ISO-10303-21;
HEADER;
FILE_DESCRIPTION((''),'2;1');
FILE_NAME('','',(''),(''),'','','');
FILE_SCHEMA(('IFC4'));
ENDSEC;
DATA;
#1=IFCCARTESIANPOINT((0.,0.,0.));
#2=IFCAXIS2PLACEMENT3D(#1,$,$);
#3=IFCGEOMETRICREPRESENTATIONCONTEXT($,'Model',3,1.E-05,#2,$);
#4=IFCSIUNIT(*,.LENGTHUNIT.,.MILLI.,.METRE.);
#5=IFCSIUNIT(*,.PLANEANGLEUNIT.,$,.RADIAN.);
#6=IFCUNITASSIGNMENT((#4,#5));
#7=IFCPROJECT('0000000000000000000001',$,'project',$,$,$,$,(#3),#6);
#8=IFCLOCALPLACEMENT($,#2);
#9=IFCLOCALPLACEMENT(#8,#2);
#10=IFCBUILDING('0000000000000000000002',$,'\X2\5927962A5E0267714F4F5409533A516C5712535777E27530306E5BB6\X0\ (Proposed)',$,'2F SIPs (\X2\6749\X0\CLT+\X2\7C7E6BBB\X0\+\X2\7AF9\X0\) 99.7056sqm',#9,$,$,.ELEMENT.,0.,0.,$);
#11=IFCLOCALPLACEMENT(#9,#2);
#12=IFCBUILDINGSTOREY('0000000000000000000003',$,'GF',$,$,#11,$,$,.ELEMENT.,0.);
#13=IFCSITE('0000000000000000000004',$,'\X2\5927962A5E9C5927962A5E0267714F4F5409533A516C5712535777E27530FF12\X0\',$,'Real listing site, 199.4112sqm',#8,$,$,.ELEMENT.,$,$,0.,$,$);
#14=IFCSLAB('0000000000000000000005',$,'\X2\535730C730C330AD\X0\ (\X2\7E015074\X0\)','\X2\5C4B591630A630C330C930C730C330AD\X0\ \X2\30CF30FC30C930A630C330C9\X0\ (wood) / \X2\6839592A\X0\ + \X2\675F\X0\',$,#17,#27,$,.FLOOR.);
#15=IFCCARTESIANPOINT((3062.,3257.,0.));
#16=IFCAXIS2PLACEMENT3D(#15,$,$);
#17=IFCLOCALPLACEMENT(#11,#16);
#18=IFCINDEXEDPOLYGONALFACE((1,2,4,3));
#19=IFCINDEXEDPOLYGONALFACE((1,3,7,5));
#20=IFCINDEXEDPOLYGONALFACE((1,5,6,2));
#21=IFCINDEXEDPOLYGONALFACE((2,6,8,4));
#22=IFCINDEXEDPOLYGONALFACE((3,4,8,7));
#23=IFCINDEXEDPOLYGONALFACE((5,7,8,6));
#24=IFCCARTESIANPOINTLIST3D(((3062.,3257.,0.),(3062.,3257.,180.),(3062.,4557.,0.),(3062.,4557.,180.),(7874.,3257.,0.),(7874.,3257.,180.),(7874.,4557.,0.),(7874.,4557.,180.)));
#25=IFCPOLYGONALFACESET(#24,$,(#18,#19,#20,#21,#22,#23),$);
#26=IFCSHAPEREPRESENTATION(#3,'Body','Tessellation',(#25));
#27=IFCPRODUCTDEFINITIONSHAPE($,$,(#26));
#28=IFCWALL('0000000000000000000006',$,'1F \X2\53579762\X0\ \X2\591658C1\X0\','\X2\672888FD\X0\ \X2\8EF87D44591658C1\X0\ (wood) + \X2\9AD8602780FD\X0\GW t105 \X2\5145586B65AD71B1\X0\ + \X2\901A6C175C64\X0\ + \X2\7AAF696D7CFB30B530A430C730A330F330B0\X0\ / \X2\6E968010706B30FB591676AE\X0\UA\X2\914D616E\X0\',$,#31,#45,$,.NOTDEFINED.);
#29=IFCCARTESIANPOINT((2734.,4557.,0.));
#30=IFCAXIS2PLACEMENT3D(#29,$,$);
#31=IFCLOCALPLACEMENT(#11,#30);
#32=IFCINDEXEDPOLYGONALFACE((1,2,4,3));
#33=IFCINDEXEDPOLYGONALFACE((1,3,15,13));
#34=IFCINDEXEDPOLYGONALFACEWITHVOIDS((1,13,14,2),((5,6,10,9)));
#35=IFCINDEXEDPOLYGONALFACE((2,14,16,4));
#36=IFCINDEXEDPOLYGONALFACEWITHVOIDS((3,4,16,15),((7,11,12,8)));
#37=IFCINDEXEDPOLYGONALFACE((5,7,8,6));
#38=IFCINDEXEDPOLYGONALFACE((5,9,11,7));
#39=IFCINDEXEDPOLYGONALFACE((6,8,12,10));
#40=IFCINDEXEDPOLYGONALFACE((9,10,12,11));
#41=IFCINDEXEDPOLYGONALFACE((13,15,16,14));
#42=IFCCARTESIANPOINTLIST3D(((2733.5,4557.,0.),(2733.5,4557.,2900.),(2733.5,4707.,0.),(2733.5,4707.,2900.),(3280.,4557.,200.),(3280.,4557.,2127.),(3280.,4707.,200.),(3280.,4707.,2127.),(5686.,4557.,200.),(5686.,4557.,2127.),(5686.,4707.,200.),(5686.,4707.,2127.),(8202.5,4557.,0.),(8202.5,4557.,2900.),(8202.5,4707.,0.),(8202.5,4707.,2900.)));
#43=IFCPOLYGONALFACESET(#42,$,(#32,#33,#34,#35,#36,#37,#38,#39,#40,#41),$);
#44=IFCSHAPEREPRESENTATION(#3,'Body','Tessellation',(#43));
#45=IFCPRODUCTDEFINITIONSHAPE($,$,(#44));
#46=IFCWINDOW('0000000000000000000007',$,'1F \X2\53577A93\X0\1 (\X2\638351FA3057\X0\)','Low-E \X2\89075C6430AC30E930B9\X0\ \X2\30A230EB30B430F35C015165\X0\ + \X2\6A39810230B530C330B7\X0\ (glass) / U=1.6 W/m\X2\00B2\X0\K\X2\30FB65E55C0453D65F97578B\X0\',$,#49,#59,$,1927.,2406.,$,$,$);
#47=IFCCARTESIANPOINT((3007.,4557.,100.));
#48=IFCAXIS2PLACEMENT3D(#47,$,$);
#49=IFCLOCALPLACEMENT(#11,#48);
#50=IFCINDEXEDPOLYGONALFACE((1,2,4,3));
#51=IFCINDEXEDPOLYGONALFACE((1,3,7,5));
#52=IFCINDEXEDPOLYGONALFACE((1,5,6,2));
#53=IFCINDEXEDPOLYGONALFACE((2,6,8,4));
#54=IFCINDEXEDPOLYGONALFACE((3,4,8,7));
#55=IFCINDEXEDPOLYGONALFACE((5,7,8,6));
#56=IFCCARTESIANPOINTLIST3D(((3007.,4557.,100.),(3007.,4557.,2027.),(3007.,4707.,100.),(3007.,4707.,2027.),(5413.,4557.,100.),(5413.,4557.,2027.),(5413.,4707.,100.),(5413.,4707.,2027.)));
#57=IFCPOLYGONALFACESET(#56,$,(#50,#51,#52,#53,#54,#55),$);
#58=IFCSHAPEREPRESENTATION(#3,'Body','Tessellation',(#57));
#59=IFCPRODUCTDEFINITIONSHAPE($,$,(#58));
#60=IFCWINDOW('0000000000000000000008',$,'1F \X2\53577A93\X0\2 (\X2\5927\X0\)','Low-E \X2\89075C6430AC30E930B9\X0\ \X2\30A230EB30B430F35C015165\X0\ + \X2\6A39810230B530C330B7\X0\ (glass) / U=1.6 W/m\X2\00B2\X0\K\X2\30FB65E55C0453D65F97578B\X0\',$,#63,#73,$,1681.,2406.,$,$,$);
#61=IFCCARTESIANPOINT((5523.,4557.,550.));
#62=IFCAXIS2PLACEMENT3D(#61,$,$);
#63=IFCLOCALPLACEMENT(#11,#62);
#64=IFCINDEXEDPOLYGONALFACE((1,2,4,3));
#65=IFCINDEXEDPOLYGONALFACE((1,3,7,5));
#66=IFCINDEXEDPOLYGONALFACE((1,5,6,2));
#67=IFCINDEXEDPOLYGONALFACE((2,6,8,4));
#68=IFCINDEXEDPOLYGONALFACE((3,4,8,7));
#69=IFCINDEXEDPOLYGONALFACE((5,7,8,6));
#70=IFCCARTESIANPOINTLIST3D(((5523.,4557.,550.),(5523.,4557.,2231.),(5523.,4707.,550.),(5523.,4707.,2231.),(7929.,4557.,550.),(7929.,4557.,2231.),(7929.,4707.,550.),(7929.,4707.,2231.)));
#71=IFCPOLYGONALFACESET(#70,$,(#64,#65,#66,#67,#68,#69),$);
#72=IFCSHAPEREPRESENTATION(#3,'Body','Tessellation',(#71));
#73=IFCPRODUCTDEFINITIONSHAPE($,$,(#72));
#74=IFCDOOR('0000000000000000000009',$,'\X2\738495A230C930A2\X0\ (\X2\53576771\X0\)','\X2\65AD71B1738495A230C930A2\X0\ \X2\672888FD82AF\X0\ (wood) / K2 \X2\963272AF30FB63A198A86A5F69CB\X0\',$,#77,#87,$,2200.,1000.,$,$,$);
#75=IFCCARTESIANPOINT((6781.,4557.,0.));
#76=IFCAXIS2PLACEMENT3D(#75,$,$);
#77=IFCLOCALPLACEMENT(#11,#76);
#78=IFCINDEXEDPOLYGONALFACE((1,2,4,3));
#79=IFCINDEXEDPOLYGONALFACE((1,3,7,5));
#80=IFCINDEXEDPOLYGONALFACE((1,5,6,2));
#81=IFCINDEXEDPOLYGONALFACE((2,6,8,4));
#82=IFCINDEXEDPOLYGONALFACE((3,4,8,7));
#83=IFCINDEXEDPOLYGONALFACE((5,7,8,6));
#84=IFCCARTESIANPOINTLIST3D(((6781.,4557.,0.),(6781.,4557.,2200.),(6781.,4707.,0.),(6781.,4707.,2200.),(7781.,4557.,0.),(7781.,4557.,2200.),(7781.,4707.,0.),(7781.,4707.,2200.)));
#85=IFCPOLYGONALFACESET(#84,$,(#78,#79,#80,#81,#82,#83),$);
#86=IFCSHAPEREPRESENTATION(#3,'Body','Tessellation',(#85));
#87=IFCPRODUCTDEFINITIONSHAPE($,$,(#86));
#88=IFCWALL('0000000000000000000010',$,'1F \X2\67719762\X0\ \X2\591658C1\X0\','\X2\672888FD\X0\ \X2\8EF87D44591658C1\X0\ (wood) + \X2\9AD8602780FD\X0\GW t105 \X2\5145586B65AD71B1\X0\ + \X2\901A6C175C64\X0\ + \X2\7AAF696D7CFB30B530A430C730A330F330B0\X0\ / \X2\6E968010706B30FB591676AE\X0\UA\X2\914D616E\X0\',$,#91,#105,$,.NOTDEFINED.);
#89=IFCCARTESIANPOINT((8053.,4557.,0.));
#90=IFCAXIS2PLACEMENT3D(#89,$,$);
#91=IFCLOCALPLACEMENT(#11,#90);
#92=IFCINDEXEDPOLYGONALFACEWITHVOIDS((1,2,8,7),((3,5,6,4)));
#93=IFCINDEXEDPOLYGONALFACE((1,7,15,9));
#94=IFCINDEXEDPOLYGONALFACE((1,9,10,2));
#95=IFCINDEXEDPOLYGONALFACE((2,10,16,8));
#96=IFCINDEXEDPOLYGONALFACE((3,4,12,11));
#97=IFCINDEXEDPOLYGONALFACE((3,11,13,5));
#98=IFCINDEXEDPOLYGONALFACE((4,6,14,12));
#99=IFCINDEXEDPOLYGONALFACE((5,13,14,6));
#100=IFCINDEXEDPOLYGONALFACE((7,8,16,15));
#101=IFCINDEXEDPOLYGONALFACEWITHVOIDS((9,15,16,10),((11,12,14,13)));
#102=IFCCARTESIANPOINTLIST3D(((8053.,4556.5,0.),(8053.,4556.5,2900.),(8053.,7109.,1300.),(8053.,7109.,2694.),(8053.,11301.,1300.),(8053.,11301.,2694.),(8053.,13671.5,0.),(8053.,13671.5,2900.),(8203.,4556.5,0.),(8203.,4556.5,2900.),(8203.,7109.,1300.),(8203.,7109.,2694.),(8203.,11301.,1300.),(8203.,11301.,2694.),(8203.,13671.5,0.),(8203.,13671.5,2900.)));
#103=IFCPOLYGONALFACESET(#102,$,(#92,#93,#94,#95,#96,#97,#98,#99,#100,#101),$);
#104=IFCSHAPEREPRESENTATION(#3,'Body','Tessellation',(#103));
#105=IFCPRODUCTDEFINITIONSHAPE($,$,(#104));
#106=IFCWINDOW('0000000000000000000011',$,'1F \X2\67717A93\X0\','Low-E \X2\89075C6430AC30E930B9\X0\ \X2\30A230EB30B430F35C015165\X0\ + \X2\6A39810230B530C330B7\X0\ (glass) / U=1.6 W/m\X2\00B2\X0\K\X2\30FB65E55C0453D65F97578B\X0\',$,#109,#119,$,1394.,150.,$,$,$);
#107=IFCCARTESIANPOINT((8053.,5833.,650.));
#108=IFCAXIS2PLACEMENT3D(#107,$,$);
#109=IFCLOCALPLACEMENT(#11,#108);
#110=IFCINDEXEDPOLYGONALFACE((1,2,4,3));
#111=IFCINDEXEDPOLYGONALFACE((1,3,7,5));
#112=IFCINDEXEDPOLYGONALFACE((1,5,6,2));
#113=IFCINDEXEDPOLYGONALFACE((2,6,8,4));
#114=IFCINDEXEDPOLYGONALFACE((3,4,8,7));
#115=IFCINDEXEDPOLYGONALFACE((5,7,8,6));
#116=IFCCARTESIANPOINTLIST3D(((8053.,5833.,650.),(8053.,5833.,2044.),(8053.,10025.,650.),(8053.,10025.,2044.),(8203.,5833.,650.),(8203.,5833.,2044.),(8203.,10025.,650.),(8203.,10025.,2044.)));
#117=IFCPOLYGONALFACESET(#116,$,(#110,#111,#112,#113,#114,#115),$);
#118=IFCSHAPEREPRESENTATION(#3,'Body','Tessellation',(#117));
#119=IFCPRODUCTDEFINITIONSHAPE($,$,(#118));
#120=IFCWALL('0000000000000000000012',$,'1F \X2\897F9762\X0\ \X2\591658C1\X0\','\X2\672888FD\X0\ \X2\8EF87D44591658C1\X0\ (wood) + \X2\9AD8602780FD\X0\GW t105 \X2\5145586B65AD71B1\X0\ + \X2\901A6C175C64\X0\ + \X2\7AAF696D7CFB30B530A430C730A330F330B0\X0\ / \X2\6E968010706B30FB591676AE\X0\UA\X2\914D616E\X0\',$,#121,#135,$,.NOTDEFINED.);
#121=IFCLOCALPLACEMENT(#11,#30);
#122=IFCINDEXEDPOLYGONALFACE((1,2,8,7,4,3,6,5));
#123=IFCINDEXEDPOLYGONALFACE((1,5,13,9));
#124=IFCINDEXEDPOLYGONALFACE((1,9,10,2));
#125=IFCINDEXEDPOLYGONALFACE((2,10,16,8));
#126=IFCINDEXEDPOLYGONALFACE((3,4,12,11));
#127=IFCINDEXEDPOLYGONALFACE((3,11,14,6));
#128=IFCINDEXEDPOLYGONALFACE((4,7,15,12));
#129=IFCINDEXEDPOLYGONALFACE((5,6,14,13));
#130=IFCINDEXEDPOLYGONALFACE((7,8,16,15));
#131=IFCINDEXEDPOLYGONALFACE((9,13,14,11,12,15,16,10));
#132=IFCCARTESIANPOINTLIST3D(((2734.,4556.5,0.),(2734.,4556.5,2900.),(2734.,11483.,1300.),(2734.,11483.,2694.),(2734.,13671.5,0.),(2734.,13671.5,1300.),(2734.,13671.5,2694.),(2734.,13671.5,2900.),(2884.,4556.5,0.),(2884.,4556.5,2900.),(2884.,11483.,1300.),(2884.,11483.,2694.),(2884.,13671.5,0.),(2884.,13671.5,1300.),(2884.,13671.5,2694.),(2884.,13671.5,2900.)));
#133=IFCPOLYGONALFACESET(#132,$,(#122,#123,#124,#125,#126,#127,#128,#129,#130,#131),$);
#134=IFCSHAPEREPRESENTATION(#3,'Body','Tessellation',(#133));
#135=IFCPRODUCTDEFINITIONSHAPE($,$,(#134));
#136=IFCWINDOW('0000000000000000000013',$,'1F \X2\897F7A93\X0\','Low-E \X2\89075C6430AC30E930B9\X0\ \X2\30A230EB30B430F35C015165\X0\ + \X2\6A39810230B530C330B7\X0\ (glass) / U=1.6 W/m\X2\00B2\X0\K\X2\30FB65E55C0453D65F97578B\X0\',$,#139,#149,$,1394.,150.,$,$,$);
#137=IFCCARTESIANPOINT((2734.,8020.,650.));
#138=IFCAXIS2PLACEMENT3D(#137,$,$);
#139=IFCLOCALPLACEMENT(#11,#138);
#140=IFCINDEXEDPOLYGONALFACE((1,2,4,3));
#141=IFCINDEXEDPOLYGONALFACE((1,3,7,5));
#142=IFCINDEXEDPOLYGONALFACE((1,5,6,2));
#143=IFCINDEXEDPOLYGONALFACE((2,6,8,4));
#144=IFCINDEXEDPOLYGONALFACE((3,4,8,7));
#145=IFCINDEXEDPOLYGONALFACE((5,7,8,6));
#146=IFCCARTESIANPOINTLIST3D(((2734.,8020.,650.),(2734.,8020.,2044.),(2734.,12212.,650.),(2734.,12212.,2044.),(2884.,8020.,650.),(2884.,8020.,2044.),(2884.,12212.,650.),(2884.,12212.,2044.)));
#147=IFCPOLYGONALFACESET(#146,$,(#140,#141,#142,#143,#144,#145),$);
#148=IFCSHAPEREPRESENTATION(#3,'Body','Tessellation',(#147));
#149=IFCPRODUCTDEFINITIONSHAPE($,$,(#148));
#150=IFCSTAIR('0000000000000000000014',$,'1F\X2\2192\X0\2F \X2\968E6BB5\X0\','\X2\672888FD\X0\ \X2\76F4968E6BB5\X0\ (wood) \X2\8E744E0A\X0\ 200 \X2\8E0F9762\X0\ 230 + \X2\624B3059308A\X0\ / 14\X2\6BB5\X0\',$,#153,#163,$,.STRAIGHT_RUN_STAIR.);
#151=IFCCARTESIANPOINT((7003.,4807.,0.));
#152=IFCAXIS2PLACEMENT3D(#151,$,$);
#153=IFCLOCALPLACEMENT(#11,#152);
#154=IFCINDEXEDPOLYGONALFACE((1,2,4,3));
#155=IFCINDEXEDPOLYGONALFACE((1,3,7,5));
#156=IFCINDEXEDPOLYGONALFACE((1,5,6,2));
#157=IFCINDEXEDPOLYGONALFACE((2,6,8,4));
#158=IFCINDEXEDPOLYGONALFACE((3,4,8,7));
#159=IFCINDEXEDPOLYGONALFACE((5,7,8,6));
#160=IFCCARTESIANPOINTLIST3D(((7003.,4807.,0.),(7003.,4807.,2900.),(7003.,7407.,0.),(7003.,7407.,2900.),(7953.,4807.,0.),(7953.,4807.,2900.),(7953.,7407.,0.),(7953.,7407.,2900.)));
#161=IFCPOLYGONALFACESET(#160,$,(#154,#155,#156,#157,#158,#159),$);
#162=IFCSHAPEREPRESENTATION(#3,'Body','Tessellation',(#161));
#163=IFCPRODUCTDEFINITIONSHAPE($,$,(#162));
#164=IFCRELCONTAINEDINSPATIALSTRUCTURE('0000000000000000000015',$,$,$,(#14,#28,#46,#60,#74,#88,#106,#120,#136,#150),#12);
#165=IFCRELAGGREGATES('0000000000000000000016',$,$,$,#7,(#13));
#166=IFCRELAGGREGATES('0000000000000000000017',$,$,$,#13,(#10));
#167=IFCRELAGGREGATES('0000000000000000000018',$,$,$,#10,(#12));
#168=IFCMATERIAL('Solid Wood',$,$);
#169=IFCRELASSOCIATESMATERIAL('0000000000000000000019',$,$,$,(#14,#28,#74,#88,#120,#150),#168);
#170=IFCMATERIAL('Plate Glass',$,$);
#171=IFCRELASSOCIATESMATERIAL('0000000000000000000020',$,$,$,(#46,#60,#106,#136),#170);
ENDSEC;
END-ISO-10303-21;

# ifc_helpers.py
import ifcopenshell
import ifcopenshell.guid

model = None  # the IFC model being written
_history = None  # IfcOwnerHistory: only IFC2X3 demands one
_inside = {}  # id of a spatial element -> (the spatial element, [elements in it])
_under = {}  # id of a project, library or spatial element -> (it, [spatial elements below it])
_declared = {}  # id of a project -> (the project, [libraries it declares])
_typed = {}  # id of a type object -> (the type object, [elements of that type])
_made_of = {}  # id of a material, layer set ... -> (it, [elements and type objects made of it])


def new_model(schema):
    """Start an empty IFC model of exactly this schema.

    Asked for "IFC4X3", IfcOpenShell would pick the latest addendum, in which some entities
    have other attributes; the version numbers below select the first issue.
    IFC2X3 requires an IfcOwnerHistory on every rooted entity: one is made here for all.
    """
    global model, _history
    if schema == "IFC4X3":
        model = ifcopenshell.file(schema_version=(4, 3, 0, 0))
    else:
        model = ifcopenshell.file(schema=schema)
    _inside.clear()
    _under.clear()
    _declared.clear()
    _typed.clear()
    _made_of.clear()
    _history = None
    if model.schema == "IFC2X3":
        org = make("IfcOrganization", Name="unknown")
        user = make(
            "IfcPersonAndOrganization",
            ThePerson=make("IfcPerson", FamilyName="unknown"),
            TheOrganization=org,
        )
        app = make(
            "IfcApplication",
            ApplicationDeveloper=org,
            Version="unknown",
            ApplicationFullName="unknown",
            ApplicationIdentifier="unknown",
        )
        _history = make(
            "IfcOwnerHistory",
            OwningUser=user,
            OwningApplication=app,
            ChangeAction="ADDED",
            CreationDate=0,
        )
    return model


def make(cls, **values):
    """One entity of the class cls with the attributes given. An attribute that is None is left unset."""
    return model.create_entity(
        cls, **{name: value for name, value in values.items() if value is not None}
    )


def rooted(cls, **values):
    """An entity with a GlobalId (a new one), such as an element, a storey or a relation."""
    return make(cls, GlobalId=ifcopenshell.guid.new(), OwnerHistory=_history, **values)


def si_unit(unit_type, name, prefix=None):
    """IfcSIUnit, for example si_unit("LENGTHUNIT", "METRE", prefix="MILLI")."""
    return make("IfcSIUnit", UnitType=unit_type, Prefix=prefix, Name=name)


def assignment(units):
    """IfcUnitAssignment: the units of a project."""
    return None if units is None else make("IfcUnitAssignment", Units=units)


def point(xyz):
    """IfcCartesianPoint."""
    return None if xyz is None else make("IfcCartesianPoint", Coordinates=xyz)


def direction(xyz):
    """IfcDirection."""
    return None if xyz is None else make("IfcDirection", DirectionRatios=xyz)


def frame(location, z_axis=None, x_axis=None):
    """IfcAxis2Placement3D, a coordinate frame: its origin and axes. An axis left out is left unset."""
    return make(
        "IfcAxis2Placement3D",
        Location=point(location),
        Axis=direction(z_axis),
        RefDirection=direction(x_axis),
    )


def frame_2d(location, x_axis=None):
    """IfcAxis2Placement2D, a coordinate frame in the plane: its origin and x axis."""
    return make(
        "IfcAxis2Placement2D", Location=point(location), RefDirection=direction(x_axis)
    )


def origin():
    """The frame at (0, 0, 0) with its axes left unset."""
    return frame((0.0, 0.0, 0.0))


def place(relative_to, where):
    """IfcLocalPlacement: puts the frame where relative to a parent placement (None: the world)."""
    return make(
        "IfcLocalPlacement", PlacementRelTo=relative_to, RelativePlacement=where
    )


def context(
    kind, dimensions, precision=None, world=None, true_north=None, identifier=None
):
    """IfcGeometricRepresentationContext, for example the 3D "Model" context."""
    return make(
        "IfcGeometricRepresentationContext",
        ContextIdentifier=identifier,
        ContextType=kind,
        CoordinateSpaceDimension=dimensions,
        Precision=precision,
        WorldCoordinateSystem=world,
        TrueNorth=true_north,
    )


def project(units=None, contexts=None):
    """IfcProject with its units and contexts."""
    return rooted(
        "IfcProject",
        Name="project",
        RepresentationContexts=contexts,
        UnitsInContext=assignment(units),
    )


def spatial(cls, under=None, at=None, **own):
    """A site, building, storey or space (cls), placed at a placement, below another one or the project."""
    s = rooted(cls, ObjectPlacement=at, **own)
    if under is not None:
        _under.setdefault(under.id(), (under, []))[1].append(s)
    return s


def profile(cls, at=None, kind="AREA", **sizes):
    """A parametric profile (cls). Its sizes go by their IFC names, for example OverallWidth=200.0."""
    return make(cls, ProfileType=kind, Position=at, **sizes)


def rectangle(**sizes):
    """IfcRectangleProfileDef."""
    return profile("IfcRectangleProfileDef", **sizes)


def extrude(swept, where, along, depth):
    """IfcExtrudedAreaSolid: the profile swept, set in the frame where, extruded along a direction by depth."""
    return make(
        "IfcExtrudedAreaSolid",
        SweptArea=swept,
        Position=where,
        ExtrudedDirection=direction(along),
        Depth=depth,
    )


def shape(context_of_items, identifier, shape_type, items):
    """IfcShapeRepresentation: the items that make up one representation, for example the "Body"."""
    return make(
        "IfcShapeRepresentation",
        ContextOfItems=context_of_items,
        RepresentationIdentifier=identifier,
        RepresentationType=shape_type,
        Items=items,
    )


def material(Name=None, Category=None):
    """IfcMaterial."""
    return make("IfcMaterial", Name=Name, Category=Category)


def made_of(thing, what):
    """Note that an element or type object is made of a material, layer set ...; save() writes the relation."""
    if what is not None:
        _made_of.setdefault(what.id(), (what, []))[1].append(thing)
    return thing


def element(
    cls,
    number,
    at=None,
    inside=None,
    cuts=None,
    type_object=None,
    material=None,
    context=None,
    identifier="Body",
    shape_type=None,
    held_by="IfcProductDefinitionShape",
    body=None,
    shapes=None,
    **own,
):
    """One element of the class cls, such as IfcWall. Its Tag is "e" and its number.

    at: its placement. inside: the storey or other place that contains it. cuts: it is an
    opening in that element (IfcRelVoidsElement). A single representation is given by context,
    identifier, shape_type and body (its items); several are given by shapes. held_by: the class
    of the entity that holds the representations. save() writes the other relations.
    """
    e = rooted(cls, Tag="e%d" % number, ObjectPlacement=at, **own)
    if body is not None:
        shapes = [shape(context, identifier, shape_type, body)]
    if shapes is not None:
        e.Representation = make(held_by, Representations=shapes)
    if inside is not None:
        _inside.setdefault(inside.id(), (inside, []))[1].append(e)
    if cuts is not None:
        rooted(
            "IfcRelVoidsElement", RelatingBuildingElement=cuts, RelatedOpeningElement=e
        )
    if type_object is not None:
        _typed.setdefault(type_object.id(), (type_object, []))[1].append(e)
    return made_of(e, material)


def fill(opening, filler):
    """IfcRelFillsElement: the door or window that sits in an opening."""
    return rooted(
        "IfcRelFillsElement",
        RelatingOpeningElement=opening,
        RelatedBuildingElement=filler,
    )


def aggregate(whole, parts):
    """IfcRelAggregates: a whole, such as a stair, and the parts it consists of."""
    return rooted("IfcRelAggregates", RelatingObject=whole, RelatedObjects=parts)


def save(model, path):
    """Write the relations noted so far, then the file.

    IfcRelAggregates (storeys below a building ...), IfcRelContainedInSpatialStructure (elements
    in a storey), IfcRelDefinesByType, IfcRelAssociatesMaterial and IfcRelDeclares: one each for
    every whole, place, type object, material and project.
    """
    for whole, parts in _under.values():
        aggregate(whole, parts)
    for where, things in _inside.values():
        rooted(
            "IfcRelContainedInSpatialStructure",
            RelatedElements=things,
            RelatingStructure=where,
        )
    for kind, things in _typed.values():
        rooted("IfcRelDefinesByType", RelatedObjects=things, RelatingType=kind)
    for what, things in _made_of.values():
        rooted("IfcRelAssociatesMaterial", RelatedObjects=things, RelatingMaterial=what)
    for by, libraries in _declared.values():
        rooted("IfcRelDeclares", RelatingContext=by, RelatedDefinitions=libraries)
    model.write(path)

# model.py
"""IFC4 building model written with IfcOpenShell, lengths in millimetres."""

from ifc_helpers import new_model, si_unit, frame, frame_2d, origin, place, context, project, spatial, rectangle, extrude, material, element, fill, save


model = new_model("IFC4")

# Units and contexts
model_context = context("Model", 3, precision=1e-05, world=origin())
ifc_project = project(units=[si_unit("LENGTHUNIT", "METRE", prefix="MILLI"), si_unit("PLANEANGLEUNIT", "RADIAN")], contexts=[model_context])

# Site, building, storey
site_placement = place(None, origin())
site = spatial("IfcSite", under=ifc_project, at=site_placement, Name="大阪府大阪市東住吉区公園南矢田２", ObjectType="Real listing site, 199.4112sqm", CompositionType="ELEMENT", RefElevation=0.0)
building_placement = place(site_placement, origin())
building = spatial("IfcBuilding", under=site, at=building_placement, Name="大阪市東住吉区公園南矢田の家 (Proposed)", ObjectType="2F SIPs (杉CLT+籾殻+竹) 99.7056sqm", CompositionType="ELEMENT", ElevationOfRefHeight=0.0, ElevationOfTerrain=0.0)
storey_placement = place(building_placement, origin())
storey = spatial("IfcBuildingStorey", under=building, at=storey_placement, Name="GF", CompositionType="ELEMENT", Elevation=0.0)

# Slab
ifc_material_1 = material(Name="Solid Wood")
slab_1_placement = place(storey_placement, frame((3062.0, 3257.0, 0.0)))
element("IfcSlab", 1, at=slab_1_placement, inside=storey, material=ifc_material_1, Name="南デッキ (縁側)", Description="屋外ウッドデッキ ハードウッド (wood) / 根太 + 束", PredefinedType="FLOOR", context=model_context, shape_type="SweptSolid", body=[
    extrude(rectangle(XDim=4812.0, YDim=1300.0, at=frame_2d((2406.0, 650.0))), frame((3062.0, 3257.0, 0.0)), (0.0, 0.0, 1.0), 180.0),
])

# Wall, openings, windows, door
wall_1_placement = place(storey_placement, frame((2734.0, 4557.0, 0.0)))
wall_1 = element("IfcWall", 2, at=wall_1_placement, inside=storey, material=ifc_material_1, Name="1F 南面 外壁", Description="木製 軸組外壁 (wood) + 高性能GW t105 充填断熱 + 通気層 + 窯業系サイディング / 準耐火・外皮UA配慮", PredefinedType="NOTDEFINED", context=model_context, shape_type="SweptSolid", body=[
    extrude(rectangle(XDim=5469.0, YDim=150.0, at=frame_2d((2734.0, 75.0))), frame((2734.0, 4557.0, 0.0)), (0.0, 0.0, 1.0), 2900.0),
])
opening_1_placement = place(storey_placement, frame((3007.0, 4557.0, 100.0)))
opening_1 = element("IfcOpeningElement", 3, at=opening_1_placement, cuts=wall_1, PredefinedType="NOTDEFINED", context=model_context, shape_type="SweptSolid", body=[
    extrude(rectangle(XDim=2406.0, YDim=150.0, at=frame_2d((1203.0, 75.0))), frame((3007.0, 4557.0, 100.0)), (0.0, 0.0, 1.0), 1927.0),
])
opening_2_placement = place(storey_placement, frame((5523.0, 4557.0, 550.0)))
opening_2 = element("IfcOpeningElement", 4, at=opening_2_placement, cuts=wall_1, PredefinedType="NOTDEFINED", context=model_context, shape_type="SweptSolid", body=[
    extrude(rectangle(XDim=2406.0, YDim=150.0, at=frame_2d((1203.0, 75.0))), frame((5523.0, 4557.0, 550.0)), (0.0, 0.0, 1.0), 1681.0),
])
opening_3_placement = place(storey_placement, frame((6781.0, 4557.0, 0.0)))
opening_3 = element("IfcOpeningElement", 5, at=opening_3_placement, cuts=wall_1, PredefinedType="NOTDEFINED", context=model_context, shape_type="SweptSolid", body=[
    extrude(rectangle(XDim=1000.0, YDim=150.0, at=frame_2d((500.0, 75.0))), frame((6781.0, 4557.0, 0.0)), (0.0, 0.0, 1.0), 2200.0),
])
ifc_material_2 = material(Name="Plate Glass")
window_1_placement = place(storey_placement, frame((3007.0, 4557.0, 100.0)))
window_1 = element("IfcWindow", 6, at=window_1_placement, inside=storey, material=ifc_material_2, Name="1F 南窓1 (掃出し)", Description="Low-E 複層ガラス アルゴン封入 + 樹脂サッシ (glass) / U=1.6 W/m²K・日射取得型", OverallHeight=1927.0, OverallWidth=2406.0, context=model_context, shape_type="SweptSolid", body=[
    extrude(rectangle(XDim=2406.0, YDim=150.0, at=frame_2d((1203.0, 75.0))), frame((3007.0, 4557.0, 100.0)), (0.0, 0.0, 1.0), 1927.0),
])
fill(opening_1, window_1)
window_2_placement = place(storey_placement, frame((5523.0, 4557.0, 550.0)))
window_2 = element("IfcWindow", 7, at=window_2_placement, inside=storey, material=ifc_material_2, Name="1F 南窓2 (大)", Description="Low-E 複層ガラス アルゴン封入 + 樹脂サッシ (glass) / U=1.6 W/m²K・日射取得型", OverallHeight=1681.0, OverallWidth=2406.0, context=model_context, shape_type="SweptSolid", body=[
    extrude(rectangle(XDim=2406.0, YDim=150.0, at=frame_2d((1203.0, 75.0))), frame((5523.0, 4557.0, 550.0)), (0.0, 0.0, 1.0), 1681.0),
])
fill(opening_2, window_2)
door_placement = place(storey_placement, frame((6781.0, 4557.0, 0.0)))
door = element("IfcDoor", 8, at=door_placement, inside=storey, material=ifc_material_1, Name="玄関ドア (南東)", Description="断熱玄関ドア 木製芯 (wood) / K2 防犯・採風機構", OverallHeight=2200.0, OverallWidth=1000.0, context=model_context, shape_type="SweptSolid", body=[
    extrude(rectangle(XDim=1000.0, YDim=150.0, at=frame_2d((500.0, 75.0))), frame((6781.0, 4557.0, 0.0)), (0.0, 0.0, 1.0), 2200.0),
])
fill(opening_3, door)

# Walls, openings, windows
wall_2_placement = place(storey_placement, frame((8053.0, 4557.0, 0.0)))
wall_2 = element("IfcWall", 9, at=wall_2_placement, inside=storey, material=ifc_material_1, Name="1F 東面 外壁", Description="木製 軸組外壁 (wood) + 高性能GW t105 充填断熱 + 通気層 + 窯業系サイディング / 準耐火・外皮UA配慮", PredefinedType="NOTDEFINED", context=model_context, shape_type="SweptSolid", body=[
    extrude(rectangle(XDim=150.0, YDim=9115.0, at=frame_2d((75.0, 4557.0))), frame((8053.0, 4557.0, 0.0)), (0.0, 0.0, 1.0), 2900.0),
])
opening_4_placement = place(storey_placement, frame((8053.0, 5833.0, 650.0)))
opening_4 = element("IfcOpeningElement", 10, at=opening_4_placement, cuts=wall_2, PredefinedType="NOTDEFINED", context=model_context, shape_type="SweptSolid", body=[
    extrude(rectangle(XDim=150.0, YDim=4192.0, at=frame_2d((75.0, 2096.0))), frame((8053.0, 5833.0, 650.0)), (0.0, 0.0, 1.0), 1394.0),
])
window_3_placement = place(storey_placement, frame((8053.0, 5833.0, 650.0)))
window_3 = element("IfcWindow", 11, at=window_3_placement, inside=storey, material=ifc_material_2, Name="1F 東窓", Description="Low-E 複層ガラス アルゴン封入 + 樹脂サッシ (glass) / U=1.6 W/m²K・日射取得型", OverallHeight=1394.0, OverallWidth=150.0, context=model_context, shape_type="SweptSolid", body=[
    extrude(rectangle(XDim=150.0, YDim=4192.0, at=frame_2d((75.0, 2096.0))), frame((8053.0, 5833.0, 650.0)), (0.0, 0.0, 1.0), 1394.0),
])
fill(opening_4, window_3)
wall_3_placement = place(storey_placement, frame((2734.0, 4557.0, 0.0)))
wall_3 = element("IfcWall", 12, at=wall_3_placement, inside=storey, material=ifc_material_1, Name="1F 西面 外壁", Description="木製 軸組外壁 (wood) + 高性能GW t105 充填断熱 + 通気層 + 窯業系サイディング / 準耐火・外皮UA配慮", PredefinedType="NOTDEFINED", context=model_context, shape_type="SweptSolid", body=[
    extrude(rectangle(XDim=150.0, YDim=9115.0, at=frame_2d((75.0, 4557.0))), frame((2734.0, 4557.0, 0.0)), (0.0, 0.0, 1.0), 2900.0),
])
opening_5_placement = place(storey_placement, frame((2734.0, 8020.0, 650.0)))
opening_5 = element("IfcOpeningElement", 13, at=opening_5_placement, cuts=wall_3, PredefinedType="NOTDEFINED", context=model_context, shape_type="SweptSolid", body=[
    extrude(rectangle(XDim=150.0, YDim=4192.0, at=frame_2d((75.0, 2096.0))), frame((2734.0, 8020.0, 650.0)), (0.0, 0.0, 1.0), 1394.0),
])
window_4_placement = place(storey_placement, frame((2734.0, 8020.0, 650.0)))
window_4 = element("IfcWindow", 14, at=window_4_placement, inside=storey, material=ifc_material_2, Name="1F 西窓", Description="Low-E 複層ガラス アルゴン封入 + 樹脂サッシ (glass) / U=1.6 W/m²K・日射取得型", OverallHeight=1394.0, OverallWidth=150.0, context=model_context, shape_type="SweptSolid", body=[
    extrude(rectangle(XDim=150.0, YDim=4192.0, at=frame_2d((75.0, 2096.0))), frame((2734.0, 8020.0, 650.0)), (0.0, 0.0, 1.0), 1394.0),
])
fill(opening_5, window_4)

# Stair
stair_placement = place(storey_placement, frame((7003.0, 4807.0, 0.0)))
element("IfcStair", 15, at=stair_placement, inside=storey, material=ifc_material_1, Name="1F→2F 階段", Description="木製 直階段 (wood) 蹴上 200 踏面 230 + 手すり / 14段", PredefinedType="STRAIGHT_RUN_STAIR", context=model_context, shape_type="SweptSolid", body=[
    extrude(rectangle(XDim=950.0, YDim=2600.0, at=frame_2d((475.0, 1300.0))), frame((7003.0, 4807.0, 0.0)), (0.0, 0.0, 1.0), 2900.0),
])

save(model, "model.ifc")
